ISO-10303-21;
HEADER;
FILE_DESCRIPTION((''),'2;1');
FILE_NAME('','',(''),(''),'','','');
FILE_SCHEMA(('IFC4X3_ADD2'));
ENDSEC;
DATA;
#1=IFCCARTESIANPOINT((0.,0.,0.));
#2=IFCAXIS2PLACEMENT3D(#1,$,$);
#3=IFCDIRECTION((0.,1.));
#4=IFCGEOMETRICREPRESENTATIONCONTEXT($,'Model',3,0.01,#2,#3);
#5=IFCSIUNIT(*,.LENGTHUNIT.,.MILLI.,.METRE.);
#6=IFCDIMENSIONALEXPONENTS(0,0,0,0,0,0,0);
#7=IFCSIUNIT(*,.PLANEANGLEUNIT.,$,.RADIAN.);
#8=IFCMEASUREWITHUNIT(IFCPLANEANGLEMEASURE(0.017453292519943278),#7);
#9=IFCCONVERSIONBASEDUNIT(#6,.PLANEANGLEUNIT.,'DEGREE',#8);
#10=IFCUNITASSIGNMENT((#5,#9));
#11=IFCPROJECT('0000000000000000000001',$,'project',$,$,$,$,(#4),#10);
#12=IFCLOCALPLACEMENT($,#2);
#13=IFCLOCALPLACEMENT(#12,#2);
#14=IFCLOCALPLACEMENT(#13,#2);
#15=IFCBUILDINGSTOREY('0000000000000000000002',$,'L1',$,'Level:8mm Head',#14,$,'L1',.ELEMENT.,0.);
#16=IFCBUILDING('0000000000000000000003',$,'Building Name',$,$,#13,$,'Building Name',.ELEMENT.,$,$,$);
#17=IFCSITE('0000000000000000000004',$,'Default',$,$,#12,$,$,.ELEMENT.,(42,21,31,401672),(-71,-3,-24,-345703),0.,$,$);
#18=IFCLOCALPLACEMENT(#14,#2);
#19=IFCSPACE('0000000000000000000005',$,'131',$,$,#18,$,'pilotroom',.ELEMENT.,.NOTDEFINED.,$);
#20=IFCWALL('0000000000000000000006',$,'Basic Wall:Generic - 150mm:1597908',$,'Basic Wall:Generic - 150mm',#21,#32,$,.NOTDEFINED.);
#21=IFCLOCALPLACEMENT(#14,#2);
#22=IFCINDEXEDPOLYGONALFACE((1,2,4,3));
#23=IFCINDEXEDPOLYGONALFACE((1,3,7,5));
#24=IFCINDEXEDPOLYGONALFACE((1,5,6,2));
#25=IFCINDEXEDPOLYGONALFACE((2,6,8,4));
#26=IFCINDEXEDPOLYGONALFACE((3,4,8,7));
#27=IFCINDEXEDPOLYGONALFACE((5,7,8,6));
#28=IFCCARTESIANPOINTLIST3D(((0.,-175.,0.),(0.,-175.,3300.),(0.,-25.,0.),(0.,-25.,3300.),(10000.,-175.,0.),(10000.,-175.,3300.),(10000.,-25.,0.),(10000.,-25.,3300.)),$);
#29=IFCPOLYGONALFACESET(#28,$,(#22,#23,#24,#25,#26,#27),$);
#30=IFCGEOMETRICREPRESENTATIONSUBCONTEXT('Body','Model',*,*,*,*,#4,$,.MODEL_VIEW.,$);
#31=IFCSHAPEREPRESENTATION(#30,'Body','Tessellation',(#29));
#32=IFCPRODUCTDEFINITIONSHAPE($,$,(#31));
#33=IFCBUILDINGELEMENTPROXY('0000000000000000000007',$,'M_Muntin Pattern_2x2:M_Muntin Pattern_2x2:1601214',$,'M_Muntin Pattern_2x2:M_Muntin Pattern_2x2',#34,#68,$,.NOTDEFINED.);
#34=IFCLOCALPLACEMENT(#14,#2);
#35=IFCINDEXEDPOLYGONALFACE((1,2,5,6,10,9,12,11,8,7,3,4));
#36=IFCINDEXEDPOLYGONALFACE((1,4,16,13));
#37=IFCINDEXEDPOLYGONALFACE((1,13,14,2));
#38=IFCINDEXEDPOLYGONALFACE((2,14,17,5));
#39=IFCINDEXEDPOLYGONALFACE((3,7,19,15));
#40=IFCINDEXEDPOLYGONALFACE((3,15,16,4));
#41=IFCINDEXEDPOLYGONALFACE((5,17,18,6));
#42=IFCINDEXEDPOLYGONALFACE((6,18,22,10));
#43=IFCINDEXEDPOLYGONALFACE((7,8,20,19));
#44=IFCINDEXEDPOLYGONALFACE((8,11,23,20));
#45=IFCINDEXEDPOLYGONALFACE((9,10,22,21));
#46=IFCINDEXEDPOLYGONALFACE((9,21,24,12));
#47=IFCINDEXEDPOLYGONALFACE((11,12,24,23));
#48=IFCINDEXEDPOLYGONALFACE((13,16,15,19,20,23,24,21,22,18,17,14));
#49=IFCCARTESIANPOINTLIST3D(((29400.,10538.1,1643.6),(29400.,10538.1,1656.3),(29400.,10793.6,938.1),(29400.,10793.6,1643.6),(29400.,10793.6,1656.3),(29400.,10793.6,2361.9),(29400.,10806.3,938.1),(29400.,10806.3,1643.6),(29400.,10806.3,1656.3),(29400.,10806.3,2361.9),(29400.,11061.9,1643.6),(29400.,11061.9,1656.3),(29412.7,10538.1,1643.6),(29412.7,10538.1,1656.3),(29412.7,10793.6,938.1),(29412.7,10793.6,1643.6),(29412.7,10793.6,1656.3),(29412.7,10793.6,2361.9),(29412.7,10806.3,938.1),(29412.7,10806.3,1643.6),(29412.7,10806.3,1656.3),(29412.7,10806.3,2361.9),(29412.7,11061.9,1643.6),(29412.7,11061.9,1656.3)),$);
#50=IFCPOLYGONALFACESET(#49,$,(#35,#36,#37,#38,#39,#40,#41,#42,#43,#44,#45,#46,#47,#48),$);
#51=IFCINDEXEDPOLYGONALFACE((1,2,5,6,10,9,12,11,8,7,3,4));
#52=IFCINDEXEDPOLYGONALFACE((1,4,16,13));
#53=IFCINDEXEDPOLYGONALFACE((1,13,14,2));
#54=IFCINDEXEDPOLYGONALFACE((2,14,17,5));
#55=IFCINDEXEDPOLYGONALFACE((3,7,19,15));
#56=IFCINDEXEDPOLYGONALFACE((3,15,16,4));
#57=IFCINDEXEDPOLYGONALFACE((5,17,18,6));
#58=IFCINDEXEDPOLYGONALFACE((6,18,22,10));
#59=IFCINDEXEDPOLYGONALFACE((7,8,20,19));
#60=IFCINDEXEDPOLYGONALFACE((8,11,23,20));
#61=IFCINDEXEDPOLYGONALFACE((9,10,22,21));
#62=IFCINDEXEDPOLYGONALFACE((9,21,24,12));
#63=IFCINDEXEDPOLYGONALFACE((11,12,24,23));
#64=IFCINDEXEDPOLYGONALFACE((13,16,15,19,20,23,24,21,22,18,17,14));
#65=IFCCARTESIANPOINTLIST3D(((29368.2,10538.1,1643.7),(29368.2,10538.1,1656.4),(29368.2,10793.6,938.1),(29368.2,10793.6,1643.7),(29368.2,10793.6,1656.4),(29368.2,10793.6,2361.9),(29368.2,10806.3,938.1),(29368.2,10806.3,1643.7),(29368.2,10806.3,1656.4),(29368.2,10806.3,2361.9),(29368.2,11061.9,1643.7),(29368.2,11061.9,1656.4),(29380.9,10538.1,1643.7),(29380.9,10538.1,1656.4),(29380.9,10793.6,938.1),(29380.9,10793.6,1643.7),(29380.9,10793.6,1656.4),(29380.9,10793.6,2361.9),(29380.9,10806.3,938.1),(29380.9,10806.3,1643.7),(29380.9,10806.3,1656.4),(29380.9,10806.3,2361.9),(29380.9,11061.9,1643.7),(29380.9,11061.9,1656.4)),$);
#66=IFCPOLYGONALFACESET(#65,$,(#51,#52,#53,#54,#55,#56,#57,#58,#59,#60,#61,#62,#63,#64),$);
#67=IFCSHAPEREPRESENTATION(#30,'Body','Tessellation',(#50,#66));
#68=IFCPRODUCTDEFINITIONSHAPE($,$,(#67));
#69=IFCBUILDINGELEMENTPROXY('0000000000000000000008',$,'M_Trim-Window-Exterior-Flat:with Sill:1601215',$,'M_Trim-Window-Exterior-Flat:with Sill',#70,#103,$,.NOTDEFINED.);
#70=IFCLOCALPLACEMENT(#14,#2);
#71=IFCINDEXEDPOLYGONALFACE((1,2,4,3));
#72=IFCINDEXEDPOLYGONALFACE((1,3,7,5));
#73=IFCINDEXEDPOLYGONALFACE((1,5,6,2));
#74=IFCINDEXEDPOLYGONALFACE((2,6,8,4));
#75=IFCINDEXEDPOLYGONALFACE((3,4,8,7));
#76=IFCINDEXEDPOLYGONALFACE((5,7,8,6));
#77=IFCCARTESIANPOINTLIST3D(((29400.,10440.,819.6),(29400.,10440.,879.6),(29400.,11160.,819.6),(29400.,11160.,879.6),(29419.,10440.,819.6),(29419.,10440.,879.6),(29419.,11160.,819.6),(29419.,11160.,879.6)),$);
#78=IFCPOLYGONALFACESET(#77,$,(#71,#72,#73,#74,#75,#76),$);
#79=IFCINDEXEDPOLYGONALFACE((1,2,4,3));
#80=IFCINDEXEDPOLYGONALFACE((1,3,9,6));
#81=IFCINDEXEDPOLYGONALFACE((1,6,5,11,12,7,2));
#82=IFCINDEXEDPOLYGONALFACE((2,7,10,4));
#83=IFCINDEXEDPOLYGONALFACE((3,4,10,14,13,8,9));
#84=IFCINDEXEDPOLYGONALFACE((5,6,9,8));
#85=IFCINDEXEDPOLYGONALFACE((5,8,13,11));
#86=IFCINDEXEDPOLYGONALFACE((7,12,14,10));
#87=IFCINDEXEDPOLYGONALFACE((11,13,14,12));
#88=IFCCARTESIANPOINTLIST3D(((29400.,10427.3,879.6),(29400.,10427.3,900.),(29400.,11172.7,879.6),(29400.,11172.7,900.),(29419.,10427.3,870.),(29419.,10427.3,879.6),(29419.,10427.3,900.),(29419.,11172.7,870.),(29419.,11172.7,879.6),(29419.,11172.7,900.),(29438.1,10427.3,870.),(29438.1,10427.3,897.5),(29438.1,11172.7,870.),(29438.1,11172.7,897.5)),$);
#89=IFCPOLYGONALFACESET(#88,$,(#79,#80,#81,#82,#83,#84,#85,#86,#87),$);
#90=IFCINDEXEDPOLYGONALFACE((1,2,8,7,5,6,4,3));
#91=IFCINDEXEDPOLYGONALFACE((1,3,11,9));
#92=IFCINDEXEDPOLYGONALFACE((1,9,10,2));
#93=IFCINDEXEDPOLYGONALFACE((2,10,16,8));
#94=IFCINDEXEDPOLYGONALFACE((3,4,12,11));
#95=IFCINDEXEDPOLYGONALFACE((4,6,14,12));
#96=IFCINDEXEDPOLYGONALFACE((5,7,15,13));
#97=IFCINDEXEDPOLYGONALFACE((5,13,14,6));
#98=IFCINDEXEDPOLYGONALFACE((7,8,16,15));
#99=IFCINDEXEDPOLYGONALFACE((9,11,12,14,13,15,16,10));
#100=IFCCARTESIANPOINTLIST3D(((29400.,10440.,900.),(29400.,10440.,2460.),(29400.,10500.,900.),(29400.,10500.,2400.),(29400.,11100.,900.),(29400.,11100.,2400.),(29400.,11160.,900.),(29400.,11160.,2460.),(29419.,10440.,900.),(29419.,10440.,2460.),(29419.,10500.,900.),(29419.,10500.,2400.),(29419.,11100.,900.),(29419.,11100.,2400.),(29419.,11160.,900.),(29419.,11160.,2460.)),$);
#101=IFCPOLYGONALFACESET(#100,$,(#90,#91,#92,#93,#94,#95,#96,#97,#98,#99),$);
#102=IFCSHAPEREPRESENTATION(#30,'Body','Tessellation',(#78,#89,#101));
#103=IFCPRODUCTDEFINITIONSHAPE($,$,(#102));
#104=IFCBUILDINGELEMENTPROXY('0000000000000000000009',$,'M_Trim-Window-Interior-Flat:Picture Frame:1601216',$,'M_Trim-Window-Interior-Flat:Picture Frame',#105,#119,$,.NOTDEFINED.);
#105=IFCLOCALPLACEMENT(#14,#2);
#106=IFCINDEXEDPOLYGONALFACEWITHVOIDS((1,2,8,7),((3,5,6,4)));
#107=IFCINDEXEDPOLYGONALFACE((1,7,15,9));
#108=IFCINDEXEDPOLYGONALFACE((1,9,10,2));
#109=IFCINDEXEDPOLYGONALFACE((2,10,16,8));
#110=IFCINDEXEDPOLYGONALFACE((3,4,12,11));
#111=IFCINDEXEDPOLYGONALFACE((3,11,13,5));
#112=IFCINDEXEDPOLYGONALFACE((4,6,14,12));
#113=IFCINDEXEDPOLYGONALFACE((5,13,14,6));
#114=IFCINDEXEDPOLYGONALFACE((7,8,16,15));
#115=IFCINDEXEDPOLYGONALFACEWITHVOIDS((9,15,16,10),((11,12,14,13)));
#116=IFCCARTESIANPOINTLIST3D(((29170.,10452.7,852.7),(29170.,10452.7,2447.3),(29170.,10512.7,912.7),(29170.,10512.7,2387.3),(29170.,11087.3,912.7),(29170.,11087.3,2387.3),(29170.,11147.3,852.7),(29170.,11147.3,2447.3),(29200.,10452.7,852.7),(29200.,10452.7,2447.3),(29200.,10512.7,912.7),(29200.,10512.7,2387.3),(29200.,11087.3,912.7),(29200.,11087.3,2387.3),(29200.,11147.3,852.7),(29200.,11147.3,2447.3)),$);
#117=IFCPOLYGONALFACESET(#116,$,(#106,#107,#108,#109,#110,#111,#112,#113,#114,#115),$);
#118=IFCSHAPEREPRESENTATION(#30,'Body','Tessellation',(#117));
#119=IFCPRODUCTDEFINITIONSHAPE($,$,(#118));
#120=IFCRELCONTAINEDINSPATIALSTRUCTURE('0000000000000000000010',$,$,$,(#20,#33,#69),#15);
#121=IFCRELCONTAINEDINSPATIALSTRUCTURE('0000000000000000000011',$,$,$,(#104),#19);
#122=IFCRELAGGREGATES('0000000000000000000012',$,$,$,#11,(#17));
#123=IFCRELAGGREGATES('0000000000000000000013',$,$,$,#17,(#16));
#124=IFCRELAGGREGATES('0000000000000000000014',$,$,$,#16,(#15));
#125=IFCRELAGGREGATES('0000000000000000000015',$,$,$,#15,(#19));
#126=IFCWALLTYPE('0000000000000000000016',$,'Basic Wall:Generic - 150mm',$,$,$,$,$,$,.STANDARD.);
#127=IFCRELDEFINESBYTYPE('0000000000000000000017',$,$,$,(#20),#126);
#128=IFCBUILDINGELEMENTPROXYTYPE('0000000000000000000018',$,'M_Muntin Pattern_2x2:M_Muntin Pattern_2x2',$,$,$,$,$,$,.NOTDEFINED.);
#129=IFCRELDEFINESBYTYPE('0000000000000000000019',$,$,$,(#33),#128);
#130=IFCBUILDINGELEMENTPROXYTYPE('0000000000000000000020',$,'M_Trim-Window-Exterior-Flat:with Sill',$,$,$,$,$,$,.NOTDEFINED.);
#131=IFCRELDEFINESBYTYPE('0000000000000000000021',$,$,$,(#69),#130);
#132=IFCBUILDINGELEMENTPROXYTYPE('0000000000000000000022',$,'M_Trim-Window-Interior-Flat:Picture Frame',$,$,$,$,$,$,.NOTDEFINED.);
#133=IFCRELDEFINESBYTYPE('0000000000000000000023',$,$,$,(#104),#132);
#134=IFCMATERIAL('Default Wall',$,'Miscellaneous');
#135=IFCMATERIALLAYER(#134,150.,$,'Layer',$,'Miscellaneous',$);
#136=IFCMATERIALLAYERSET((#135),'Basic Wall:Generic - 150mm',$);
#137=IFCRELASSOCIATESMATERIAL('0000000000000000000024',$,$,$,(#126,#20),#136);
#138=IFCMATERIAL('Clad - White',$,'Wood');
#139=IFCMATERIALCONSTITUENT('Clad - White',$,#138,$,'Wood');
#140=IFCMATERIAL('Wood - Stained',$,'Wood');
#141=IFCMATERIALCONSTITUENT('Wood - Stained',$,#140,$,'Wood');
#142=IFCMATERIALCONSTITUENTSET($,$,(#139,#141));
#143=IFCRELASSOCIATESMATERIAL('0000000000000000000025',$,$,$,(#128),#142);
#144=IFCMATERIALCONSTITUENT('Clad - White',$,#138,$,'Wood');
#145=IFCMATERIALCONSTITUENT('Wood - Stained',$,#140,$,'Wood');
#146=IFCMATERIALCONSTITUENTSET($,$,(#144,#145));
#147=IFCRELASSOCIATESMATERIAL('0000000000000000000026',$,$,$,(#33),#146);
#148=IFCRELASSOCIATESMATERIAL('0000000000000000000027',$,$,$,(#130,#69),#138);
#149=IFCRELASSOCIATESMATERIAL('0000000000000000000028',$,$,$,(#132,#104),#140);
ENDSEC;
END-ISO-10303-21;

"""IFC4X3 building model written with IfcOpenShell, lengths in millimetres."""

from ifc_helpers import new_model, entity, si_unit, converted_unit, direction, frame, frame_2d, origin, place, context, subcontext, project, spatial, polyline, rectangle, outline, extrude, source, transform, mapped, material, layer, layer_set, constituent, constituent_set, type_object, type_shapes, element, save


model = new_model("IFC4X3")

# Units and contexts
model_context = context("Model", 3, precision=0.01, world=origin(), true_north=direction((0.0, 1.0)))
body_context = subcontext(model_context, "Body", "Model", "MODEL_VIEW")
ifc_project = project(units=[si_unit("LENGTHUNIT", "METRE", prefix="MILLI"), converted_unit("PLANEANGLEUNIT", "DEGREE", entity("IfcPlaneAngleMeasure", 0.017453292519943278), si_unit("PLANEANGLEUNIT", "RADIAN"), dimensions=[0, 0, 0, 0, 0, 0, 0])], contexts=[model_context])

# Site, building, storey
site_placement = place(None, origin())
site = spatial("IfcSite", under=ifc_project, at=site_placement, Name="Default", CompositionType="ELEMENT", RefLatitude=(42, 21, 31, 401672), RefLongitude=(-71, -3, -24, -345703), RefElevation=0.0)
building_placement = place(site_placement, origin())
building = spatial("IfcBuilding", under=site, at=building_placement, Name="Building Name", LongName="Building Name", CompositionType="ELEMENT")
storey_placement = place(building_placement, origin())
storey = spatial("IfcBuildingStorey", under=building, at=storey_placement, Name="L1", ObjectType="Level:8mm Head", LongName="L1", CompositionType="ELEMENT", Elevation=0.0)

# Shared definitions
ifc_material_1 = material(Name="Default Wall", Category="Miscellaneous")

# Wall
ifc_layer_1 = layer(ifc_material_1, 150.0, Name="Layer", Category="Miscellaneous")
ifc_layer_set_1 = layer_set([ifc_layer_1], Name="Basic Wall:Generic - 150mm")
wall_type_1 = type_object("IfcWallType", Name="Basic Wall:Generic - 150mm", PredefinedType="STANDARD", material=ifc_layer_set_1)
wall_1_placement = place(storey_placement, frame((0.0, -100.0, 0.0)))
element("IfcWall", 1, at=wall_1_placement, inside=storey, type_object=wall_type_1, material=ifc_layer_set_1, Name="Basic Wall:Generic - 150mm:1597908", ObjectType="Basic Wall:Generic - 150mm", PredefinedType="NOTDEFINED", context=body_context, shape_type="SweptSolid", body=[
    extrude(rectangle(XDim=10000.0, YDim=150.0, at=frame_2d((5000.0, 0.0), x_axis=(-1.0, 0.0))), origin(), (0.0, 0.0, 1.0), 3300.0),
])

# Building element proxies
ifc_material_2 = material(Name="Clad - White", Category="Wood")
ifc_constituent_1 = constituent(ifc_material_2, Name="Clad - White", Category="Wood")
ifc_material_3 = material(Name="Wood - Stained", Category="Wood")
ifc_constituent_2 = constituent(ifc_material_3, Name="Wood - Stained", Category="Wood")
ifc_constituent_set_1 = constituent_set(constituents=[ifc_constituent_1, ifc_constituent_2])
ifc_constituent_3 = constituent(ifc_material_2, Name="Clad - White", Category="Wood")
ifc_constituent_4 = constituent(ifc_material_3, Name="Wood - Stained", Category="Wood")
ifc_constituent_set_2 = constituent_set(constituents=[ifc_constituent_3, ifc_constituent_4])
building_element_proxy_type_1 = type_object("IfcBuildingElementProxyType", Name="M_Muntin Pattern_2x2:M_Muntin Pattern_2x2", PredefinedType="NOTDEFINED", material=ifc_constituent_set_2)
shared_shape_1 = source(origin(), body_context, "Body", "SweptSolid", [
    extrude(outline(polyline([(6.4, -6.4), (711.9, -6.4), (711.9, 6.3), (6.4, 6.3), (6.4, 261.9), (-6.3, 261.9), (-6.3, 6.3), (-711.9, 6.3), (-711.9, -6.4), (-6.3, -6.4), (-6.3, -261.9), (6.4, -261.9), (6.4, -6.4)])), frame((0.0, -22.2, 711.9), z_axis=(0.0, 1.0, 0.0), x_axis=(0.0, 0.0, 1.0)), (0.0, 0.0, 1.0), 12.7),
    extrude(outline(polyline([(6.4, -6.4), (711.9, -6.4), (711.9, 6.3), (6.4, 6.3), (6.4, 261.9), (-6.3, 261.9), (-6.3, 6.3), (-711.9, 6.3), (-711.9, -6.4), (-6.3, -6.4), (-6.3, -261.9), (6.4, -261.9), (6.4, -6.4)])), frame((0.0, 9.5, 711.9), z_axis=(0.0, 1.0, 0.0), x_axis=(0.0, 0.0, 1.0)), (0.0, 0.0, 1.0), 12.7),
])
type_shapes(building_element_proxy_type_1, [shared_shape_1])
proxy_1_placement = place(storey_placement, frame((29390.5, 10800.0, 938.1), z_axis=(0.0, 0.0, 1.0), x_axis=(0.0, 1.0, 0.0)))
element("IfcBuildingElementProxy", 2, at=proxy_1_placement, inside=storey, type_object=building_element_proxy_type_1, material=ifc_constituent_set_1, Name="M_Muntin Pattern_2x2:M_Muntin Pattern_2x2:1601214", ObjectType="M_Muntin Pattern_2x2:M_Muntin Pattern_2x2", PredefinedType="NOTDEFINED", context=body_context, shape_type="MappedRepresentation", body=[
    mapped(shared_shape_1, transform((0.0, 0.0, 0.0), scale=1.0)),
])
building_element_proxy_type_2 = type_object("IfcBuildingElementProxyType", Name="M_Trim-Window-Exterior-Flat:with Sill", PredefinedType="NOTDEFINED", material=ifc_material_2)
shared_shape_2 = source(origin(), body_context, "Body", "SweptSolid", [
    extrude(rectangle(XDim=720.0, YDim=60.0, at=frame_2d((0.0, 0.0), x_axis=(1.0, 0.0))), frame((0.0, -1550.4, 0.0), z_axis=(0.0, 0.0, 1.0), x_axis=(-1.0, 0.0, 0.0)), (0.0, 0.0, 1.0), 19.0),
    extrude(outline(polyline([(-19.0, -15.2), (0.0, -15.2), (0.0, -5.7), (19.0, -5.7), (19.0, 14.8), (0.0, 14.8), (-19.0, 12.3), (-19.0, -15.2)])), frame((-372.7, -1514.8, 19.0), z_axis=(1.0, 0.0, 0.0), x_axis=(0.0, 0.0, -1.0)), (0.0, 0.0, 1.0), 745.4),
    extrude(outline(polyline([(-795.0, -360.0), (765.0, -360.0), (765.0, -300.0), (-735.0, -300.0), (-735.0, 300.0), (765.0, 300.0), (765.0, 360.0), (-795.0, 360.0), (-795.0, -360.0)])), frame((0.0, -735.0, 0.0), z_axis=(0.0, 0.0, 1.0), x_axis=(0.0, -1.0, 0.0)), (0.0, 0.0, 1.0), 19.0),
])
type_shapes(building_element_proxy_type_2, [shared_shape_2])
proxy_2_placement = place(storey_placement, frame((29400.0, 10800.0, 2400.0), z_axis=(1.0, 0.0, 0.0), x_axis=(0.0, 1.0, 0.0)))
element("IfcBuildingElementProxy", 3, at=proxy_2_placement, inside=storey, type_object=building_element_proxy_type_2, material=ifc_material_2, Name="M_Trim-Window-Exterior-Flat:with Sill:1601215", ObjectType="M_Trim-Window-Exterior-Flat:with Sill", PredefinedType="NOTDEFINED", context=body_context, shape_type="MappedRepresentation", body=[
    mapped(shared_shape_2, transform((0.0, 0.0, 0.0), scale=1.0)),
])

# Shared definitions
space_placement = place(storey_placement, origin())
space = spatial("IfcSpace", under=storey, at=space_placement, Name="131", LongName="pilotroom", CompositionType="ELEMENT", PredefinedType="NOTDEFINED")

# Building element proxy
building_element_proxy_type_3 = type_object("IfcBuildingElementProxyType", Name="M_Trim-Window-Interior-Flat:Picture Frame", PredefinedType="NOTDEFINED", material=ifc_material_3)
shared_shape_3 = source(origin(), body_context, "Body", "SweptSolid", [
    extrude(outline(polyline([(-347.3, -797.3), (347.3, -797.3), (347.3, 797.3), (-347.3, 797.3), (-347.3, -797.3)]), holes=[polyline([(-287.3, -737.3), (-287.3, 737.3), (287.3, 737.3), (287.3, -737.3), (-287.3, -737.3)])]), frame((0.0, -750.0, 0.0), z_axis=(0.0, 0.0, 1.0), x_axis=(-1.0, 0.0, 0.0)), (0.0, 0.0, 1.0), 30.0),
])
type_shapes(building_element_proxy_type_3, [shared_shape_3])
proxy_3_placement = place(space_placement, frame((29200.0, 10800.0, 2400.0), z_axis=(-1.0, 0.0, 0.0), x_axis=(0.0, -1.0, 0.0)))
element("IfcBuildingElementProxy", 4, at=proxy_3_placement, inside=space, type_object=building_element_proxy_type_3, material=ifc_material_3, Name="M_Trim-Window-Interior-Flat:Picture Frame:1601216", ObjectType="M_Trim-Window-Interior-Flat:Picture Frame", PredefinedType="NOTDEFINED", context=body_context, shape_type="MappedRepresentation", body=[
    mapped(shared_shape_3, transform((0.0, 0.0, 0.0), scale=1.0)),
])

save(model, "model.ifc")
